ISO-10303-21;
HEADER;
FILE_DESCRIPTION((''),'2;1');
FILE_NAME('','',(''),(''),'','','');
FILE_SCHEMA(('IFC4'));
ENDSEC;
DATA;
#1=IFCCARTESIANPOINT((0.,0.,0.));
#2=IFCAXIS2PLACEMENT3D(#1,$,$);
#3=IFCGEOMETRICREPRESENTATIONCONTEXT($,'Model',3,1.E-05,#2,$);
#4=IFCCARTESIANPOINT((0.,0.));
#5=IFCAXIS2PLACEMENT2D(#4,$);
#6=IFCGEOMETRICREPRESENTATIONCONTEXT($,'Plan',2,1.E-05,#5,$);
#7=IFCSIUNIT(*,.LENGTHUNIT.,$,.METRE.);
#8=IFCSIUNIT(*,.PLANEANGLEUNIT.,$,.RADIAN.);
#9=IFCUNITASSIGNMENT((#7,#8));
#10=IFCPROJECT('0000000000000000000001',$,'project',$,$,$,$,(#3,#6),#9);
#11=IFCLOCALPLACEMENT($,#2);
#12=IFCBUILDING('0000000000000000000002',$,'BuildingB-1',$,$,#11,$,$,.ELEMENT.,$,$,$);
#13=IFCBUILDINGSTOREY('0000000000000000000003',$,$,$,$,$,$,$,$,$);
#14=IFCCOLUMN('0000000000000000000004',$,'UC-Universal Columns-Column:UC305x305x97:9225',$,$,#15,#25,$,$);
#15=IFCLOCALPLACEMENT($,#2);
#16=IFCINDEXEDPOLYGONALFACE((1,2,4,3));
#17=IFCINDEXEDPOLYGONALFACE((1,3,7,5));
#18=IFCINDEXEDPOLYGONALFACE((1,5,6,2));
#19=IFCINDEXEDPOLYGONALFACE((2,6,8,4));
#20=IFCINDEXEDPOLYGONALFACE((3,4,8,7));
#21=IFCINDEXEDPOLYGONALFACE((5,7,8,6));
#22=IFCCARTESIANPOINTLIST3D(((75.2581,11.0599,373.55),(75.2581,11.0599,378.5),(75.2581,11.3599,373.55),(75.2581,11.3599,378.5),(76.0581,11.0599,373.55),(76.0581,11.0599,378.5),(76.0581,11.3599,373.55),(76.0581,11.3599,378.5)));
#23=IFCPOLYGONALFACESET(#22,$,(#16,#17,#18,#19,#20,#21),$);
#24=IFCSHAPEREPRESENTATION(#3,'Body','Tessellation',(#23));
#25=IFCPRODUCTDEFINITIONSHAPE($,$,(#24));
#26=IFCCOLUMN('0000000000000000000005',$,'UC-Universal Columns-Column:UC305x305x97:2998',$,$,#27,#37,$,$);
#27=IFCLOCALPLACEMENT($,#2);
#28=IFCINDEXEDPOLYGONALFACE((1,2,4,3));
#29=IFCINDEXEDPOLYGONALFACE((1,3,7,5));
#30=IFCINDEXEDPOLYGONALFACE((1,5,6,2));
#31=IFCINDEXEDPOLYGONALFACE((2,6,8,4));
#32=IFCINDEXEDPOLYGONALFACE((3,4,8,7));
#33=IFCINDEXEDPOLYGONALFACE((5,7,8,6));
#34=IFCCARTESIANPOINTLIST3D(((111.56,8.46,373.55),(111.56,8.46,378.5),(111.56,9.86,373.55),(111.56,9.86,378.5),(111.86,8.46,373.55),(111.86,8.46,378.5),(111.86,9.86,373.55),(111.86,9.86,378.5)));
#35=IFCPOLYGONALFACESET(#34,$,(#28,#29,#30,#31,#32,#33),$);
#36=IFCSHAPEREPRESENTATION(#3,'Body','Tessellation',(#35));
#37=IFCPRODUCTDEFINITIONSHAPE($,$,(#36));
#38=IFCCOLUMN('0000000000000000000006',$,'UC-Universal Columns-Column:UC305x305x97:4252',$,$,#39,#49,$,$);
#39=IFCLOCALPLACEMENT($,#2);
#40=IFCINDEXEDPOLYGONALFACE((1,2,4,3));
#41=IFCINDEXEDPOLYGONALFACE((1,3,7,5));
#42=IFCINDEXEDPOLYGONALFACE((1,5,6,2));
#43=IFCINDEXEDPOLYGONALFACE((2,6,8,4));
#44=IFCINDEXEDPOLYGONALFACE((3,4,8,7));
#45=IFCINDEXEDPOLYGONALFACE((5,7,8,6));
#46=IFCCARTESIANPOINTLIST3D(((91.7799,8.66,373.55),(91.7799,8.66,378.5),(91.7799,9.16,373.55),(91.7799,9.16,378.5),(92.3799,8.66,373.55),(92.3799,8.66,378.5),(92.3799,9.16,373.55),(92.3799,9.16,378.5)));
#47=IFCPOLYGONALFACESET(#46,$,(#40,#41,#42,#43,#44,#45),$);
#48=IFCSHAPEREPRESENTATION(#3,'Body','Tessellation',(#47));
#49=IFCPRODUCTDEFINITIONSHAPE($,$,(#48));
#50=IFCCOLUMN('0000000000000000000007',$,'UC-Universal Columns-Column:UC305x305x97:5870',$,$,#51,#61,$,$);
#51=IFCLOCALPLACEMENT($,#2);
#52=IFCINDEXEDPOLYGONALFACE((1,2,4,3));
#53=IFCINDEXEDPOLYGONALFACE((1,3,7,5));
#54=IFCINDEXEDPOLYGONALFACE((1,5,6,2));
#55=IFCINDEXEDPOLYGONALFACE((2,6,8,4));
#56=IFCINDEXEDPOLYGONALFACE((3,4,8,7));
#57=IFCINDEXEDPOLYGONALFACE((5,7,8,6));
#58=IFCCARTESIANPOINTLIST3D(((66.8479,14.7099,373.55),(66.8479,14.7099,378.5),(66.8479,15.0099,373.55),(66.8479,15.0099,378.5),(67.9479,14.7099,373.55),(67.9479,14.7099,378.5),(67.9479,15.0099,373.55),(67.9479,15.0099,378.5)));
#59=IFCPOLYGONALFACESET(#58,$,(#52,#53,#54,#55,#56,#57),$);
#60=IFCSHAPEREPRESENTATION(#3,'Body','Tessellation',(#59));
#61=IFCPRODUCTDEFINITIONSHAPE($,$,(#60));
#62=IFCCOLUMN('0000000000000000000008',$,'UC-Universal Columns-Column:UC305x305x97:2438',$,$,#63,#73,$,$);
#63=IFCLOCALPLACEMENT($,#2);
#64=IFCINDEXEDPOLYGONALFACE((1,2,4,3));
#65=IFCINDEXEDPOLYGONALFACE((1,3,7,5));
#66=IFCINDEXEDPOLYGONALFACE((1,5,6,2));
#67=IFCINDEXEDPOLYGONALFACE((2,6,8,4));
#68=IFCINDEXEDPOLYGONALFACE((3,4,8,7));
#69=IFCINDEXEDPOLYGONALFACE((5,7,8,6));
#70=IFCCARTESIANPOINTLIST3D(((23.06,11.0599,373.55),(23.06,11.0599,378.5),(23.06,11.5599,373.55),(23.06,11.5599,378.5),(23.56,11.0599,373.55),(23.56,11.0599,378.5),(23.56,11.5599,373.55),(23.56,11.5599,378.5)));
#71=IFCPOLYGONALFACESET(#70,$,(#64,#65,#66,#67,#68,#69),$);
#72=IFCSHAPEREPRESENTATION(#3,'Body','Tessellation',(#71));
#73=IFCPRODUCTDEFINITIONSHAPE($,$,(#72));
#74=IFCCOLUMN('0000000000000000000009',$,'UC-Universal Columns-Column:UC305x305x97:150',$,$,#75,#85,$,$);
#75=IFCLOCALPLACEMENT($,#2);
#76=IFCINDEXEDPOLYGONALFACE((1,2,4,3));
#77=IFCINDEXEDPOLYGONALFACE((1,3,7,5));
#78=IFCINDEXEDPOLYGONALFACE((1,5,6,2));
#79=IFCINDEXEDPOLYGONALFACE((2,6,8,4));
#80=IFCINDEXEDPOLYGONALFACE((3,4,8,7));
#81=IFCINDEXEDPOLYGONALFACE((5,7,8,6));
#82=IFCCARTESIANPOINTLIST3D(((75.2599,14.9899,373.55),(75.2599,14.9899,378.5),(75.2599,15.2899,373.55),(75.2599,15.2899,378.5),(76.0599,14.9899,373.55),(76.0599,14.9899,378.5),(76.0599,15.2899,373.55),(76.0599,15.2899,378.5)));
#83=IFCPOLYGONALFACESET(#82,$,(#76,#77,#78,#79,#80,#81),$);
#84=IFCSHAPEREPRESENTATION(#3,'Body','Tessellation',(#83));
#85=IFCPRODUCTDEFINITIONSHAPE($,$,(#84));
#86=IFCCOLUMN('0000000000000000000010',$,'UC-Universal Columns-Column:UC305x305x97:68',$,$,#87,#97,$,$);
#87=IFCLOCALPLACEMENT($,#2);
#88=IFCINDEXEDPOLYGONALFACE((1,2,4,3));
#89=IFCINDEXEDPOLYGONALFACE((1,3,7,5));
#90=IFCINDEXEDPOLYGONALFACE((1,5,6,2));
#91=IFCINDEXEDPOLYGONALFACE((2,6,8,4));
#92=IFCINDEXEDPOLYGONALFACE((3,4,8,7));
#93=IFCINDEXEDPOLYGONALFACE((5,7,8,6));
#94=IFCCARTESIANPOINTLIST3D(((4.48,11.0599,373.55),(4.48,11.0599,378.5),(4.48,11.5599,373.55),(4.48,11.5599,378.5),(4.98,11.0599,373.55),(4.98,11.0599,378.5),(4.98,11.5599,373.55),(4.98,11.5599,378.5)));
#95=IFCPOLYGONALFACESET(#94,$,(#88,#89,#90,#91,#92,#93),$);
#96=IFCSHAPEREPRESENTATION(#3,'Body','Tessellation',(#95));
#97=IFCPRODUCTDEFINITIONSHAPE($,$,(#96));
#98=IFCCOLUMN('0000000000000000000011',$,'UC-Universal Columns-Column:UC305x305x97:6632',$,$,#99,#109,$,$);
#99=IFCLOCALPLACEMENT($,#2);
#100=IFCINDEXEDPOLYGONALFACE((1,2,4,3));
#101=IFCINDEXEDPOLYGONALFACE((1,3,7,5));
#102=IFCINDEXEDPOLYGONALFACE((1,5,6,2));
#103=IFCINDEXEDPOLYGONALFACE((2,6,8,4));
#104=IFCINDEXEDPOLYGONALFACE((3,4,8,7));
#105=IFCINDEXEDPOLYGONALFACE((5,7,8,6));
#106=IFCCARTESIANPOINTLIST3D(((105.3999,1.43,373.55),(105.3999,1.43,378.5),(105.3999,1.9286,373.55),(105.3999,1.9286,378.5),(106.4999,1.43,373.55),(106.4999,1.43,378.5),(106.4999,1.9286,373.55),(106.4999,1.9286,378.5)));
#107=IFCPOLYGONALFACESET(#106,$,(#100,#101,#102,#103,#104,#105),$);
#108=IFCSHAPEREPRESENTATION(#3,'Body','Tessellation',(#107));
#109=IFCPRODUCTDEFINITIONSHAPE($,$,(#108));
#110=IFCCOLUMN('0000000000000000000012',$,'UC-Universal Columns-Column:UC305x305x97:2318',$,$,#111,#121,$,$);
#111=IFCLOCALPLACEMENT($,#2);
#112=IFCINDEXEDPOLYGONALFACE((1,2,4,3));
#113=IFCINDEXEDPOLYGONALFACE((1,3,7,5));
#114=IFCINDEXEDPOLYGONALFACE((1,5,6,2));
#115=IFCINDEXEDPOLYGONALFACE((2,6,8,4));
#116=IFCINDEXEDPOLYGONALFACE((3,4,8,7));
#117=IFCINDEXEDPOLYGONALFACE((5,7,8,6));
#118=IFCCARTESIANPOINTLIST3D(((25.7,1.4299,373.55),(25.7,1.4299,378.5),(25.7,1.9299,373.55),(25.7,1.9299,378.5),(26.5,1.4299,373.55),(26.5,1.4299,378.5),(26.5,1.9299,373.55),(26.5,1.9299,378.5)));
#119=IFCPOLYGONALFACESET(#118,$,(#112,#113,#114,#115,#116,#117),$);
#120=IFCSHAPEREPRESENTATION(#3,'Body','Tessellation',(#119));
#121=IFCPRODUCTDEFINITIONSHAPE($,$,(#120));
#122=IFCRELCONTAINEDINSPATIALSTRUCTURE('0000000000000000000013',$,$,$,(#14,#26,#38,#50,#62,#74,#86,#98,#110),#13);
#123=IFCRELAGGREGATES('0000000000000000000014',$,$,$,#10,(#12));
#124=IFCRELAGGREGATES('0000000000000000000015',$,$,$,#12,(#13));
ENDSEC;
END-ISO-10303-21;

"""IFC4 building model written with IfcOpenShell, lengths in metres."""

from ifc_helpers import new_model, si_unit, origin, origin_2d, place, context, project, spatial, polyline, outline, extrude, element, save


model = new_model("IFC4")

# Units and contexts
model_context = context("Model", 3, precision=1e-05, world=origin())
plan_context = context("Plan", 2, precision=1e-05, world=origin_2d())
ifc_project = project(units=[si_unit("LENGTHUNIT", "METRE"), si_unit("PLANEANGLEUNIT", "RADIAN")], contexts=[model_context, plan_context])

# Building, storey
building_placement = place(None, origin())
building = spatial("IfcBuilding", under=ifc_project, at=building_placement, Name="BuildingB-1", CompositionType="ELEMENT")
storey = spatial("IfcBuildingStorey", under=building)

# Columns
element("IfcColumn", 1, inside=storey, Name="UC-Universal Columns-Column:UC305x305x97:9225", context=model_context, shape_type="SweptSolid", body=[
    extrude(outline(polyline([(75.2581, 11.0599, 378.5), (76.0581, 11.0599, 378.5), (76.0581, 11.3599, 378.5), (75.2581, 11.3599, 378.5), (75.2581, 11.0599, 378.5)])), None, (0.0, 0.0, -1.0), 4.95),
])
element("IfcColumn", 2, inside=storey, Name="UC-Universal Columns-Column:UC305x305x97:2998", context=model_context, shape_type="SweptSolid", body=[
    extrude(outline(polyline([(111.86, 8.46, 378.5), (111.56, 8.46, 378.5), (111.56, 9.86, 378.5), (111.86, 9.86, 378.5), (111.86, 8.46, 378.5)])), None, (0.0, 0.0, -1.0), 4.95),
])
element("IfcColumn", 3, inside=storey, Name="UC-Universal Columns-Column:UC305x305x97:4252", context=model_context, shape_type="SweptSolid", body=[
    extrude(outline(polyline([(92.3799, 8.66, 378.5), (91.7799, 8.66, 378.5), (91.7799, 9.16, 378.5), (92.3799, 9.16, 378.5), (92.3799, 8.66, 378.5)])), None, (0.0, 0.0, -1.0), 4.95),
])
element("IfcColumn", 4, inside=storey, Name="UC-Universal Columns-Column:UC305x305x97:5870", context=model_context, shape_type="SweptSolid", body=[
    extrude(outline(polyline([(66.8479, 14.7099, 378.5), (66.8479, 15.0099, 378.5), (67.9479, 15.0099, 378.5), (67.9479, 14.7099, 378.5), (66.8479, 14.7099, 378.5)])), None, (0.0, 0.0, -1.0), 4.95),
])
element("IfcColumn", 5, inside=storey, Name="UC-Universal Columns-Column:UC305x305x97:2438", context=model_context, shape_type="SweptSolid", body=[
    extrude(outline(polyline([(23.06, 11.0599, 378.5), (23.56, 11.0599, 378.5), (23.56, 11.5599, 378.5), (23.06, 11.5599, 378.5), (23.06, 11.0599, 378.5)])), None, (0.0, 0.0, -1.0), 4.95),
])
element("IfcColumn", 6, inside=storey, Name="UC-Universal Columns-Column:UC305x305x97:150", context=model_context, shape_type="SweptSolid", body=[
    extrude(outline(polyline([(75.2599, 15.2899, 378.5), (76.0599, 15.2899, 378.5), (76.0599, 14.9899, 378.5), (75.2599, 14.9899, 378.5), (75.2599, 15.2899, 378.5)])), None, (0.0, 0.0, -1.0), 4.95),
])
element("IfcColumn", 7, inside=storey, Name="UC-Universal Columns-Column:UC305x305x97:68", context=model_context, shape_type="SweptSolid", body=[
    extrude(outline(polyline([(4.98, 11.0599, 378.5), (4.48, 11.0599, 378.5), (4.48, 11.5599, 378.5), (4.98, 11.5599, 378.5), (4.98, 11.0599, 378.5)])), None, (0.0, 0.0, -1.0), 4.95),
])
element("IfcColumn", 8, inside=storey, Name="UC-Universal Columns-Column:UC305x305x97:6632", context=model_context, shape_type="SweptSolid", body=[
    extrude(outline(polyline([(106.4999, 1.43, 378.5), (105.3999, 1.43, 378.5), (105.3999, 1.9286, 378.5), (106.4999, 1.9286, 378.5), (106.4999, 1.43, 378.5)])), None, (0.0, 0.0, -1.0), 4.95),
])
element("IfcColumn", 9, inside=storey, Name="UC-Universal Columns-Column:UC305x305x97:2318", context=model_context, shape_type="SweptSolid", body=[
    extrude(outline(polyline([(25.7, 1.4299, 378.5), (26.5, 1.4299, 378.5), (26.5, 1.9299, 378.5), (25.7, 1.9299, 378.5), (25.7, 1.4299, 378.5)])), None, (0.0, 0.0, -1.0), 4.95),
])

save(model, "model.ifc")
